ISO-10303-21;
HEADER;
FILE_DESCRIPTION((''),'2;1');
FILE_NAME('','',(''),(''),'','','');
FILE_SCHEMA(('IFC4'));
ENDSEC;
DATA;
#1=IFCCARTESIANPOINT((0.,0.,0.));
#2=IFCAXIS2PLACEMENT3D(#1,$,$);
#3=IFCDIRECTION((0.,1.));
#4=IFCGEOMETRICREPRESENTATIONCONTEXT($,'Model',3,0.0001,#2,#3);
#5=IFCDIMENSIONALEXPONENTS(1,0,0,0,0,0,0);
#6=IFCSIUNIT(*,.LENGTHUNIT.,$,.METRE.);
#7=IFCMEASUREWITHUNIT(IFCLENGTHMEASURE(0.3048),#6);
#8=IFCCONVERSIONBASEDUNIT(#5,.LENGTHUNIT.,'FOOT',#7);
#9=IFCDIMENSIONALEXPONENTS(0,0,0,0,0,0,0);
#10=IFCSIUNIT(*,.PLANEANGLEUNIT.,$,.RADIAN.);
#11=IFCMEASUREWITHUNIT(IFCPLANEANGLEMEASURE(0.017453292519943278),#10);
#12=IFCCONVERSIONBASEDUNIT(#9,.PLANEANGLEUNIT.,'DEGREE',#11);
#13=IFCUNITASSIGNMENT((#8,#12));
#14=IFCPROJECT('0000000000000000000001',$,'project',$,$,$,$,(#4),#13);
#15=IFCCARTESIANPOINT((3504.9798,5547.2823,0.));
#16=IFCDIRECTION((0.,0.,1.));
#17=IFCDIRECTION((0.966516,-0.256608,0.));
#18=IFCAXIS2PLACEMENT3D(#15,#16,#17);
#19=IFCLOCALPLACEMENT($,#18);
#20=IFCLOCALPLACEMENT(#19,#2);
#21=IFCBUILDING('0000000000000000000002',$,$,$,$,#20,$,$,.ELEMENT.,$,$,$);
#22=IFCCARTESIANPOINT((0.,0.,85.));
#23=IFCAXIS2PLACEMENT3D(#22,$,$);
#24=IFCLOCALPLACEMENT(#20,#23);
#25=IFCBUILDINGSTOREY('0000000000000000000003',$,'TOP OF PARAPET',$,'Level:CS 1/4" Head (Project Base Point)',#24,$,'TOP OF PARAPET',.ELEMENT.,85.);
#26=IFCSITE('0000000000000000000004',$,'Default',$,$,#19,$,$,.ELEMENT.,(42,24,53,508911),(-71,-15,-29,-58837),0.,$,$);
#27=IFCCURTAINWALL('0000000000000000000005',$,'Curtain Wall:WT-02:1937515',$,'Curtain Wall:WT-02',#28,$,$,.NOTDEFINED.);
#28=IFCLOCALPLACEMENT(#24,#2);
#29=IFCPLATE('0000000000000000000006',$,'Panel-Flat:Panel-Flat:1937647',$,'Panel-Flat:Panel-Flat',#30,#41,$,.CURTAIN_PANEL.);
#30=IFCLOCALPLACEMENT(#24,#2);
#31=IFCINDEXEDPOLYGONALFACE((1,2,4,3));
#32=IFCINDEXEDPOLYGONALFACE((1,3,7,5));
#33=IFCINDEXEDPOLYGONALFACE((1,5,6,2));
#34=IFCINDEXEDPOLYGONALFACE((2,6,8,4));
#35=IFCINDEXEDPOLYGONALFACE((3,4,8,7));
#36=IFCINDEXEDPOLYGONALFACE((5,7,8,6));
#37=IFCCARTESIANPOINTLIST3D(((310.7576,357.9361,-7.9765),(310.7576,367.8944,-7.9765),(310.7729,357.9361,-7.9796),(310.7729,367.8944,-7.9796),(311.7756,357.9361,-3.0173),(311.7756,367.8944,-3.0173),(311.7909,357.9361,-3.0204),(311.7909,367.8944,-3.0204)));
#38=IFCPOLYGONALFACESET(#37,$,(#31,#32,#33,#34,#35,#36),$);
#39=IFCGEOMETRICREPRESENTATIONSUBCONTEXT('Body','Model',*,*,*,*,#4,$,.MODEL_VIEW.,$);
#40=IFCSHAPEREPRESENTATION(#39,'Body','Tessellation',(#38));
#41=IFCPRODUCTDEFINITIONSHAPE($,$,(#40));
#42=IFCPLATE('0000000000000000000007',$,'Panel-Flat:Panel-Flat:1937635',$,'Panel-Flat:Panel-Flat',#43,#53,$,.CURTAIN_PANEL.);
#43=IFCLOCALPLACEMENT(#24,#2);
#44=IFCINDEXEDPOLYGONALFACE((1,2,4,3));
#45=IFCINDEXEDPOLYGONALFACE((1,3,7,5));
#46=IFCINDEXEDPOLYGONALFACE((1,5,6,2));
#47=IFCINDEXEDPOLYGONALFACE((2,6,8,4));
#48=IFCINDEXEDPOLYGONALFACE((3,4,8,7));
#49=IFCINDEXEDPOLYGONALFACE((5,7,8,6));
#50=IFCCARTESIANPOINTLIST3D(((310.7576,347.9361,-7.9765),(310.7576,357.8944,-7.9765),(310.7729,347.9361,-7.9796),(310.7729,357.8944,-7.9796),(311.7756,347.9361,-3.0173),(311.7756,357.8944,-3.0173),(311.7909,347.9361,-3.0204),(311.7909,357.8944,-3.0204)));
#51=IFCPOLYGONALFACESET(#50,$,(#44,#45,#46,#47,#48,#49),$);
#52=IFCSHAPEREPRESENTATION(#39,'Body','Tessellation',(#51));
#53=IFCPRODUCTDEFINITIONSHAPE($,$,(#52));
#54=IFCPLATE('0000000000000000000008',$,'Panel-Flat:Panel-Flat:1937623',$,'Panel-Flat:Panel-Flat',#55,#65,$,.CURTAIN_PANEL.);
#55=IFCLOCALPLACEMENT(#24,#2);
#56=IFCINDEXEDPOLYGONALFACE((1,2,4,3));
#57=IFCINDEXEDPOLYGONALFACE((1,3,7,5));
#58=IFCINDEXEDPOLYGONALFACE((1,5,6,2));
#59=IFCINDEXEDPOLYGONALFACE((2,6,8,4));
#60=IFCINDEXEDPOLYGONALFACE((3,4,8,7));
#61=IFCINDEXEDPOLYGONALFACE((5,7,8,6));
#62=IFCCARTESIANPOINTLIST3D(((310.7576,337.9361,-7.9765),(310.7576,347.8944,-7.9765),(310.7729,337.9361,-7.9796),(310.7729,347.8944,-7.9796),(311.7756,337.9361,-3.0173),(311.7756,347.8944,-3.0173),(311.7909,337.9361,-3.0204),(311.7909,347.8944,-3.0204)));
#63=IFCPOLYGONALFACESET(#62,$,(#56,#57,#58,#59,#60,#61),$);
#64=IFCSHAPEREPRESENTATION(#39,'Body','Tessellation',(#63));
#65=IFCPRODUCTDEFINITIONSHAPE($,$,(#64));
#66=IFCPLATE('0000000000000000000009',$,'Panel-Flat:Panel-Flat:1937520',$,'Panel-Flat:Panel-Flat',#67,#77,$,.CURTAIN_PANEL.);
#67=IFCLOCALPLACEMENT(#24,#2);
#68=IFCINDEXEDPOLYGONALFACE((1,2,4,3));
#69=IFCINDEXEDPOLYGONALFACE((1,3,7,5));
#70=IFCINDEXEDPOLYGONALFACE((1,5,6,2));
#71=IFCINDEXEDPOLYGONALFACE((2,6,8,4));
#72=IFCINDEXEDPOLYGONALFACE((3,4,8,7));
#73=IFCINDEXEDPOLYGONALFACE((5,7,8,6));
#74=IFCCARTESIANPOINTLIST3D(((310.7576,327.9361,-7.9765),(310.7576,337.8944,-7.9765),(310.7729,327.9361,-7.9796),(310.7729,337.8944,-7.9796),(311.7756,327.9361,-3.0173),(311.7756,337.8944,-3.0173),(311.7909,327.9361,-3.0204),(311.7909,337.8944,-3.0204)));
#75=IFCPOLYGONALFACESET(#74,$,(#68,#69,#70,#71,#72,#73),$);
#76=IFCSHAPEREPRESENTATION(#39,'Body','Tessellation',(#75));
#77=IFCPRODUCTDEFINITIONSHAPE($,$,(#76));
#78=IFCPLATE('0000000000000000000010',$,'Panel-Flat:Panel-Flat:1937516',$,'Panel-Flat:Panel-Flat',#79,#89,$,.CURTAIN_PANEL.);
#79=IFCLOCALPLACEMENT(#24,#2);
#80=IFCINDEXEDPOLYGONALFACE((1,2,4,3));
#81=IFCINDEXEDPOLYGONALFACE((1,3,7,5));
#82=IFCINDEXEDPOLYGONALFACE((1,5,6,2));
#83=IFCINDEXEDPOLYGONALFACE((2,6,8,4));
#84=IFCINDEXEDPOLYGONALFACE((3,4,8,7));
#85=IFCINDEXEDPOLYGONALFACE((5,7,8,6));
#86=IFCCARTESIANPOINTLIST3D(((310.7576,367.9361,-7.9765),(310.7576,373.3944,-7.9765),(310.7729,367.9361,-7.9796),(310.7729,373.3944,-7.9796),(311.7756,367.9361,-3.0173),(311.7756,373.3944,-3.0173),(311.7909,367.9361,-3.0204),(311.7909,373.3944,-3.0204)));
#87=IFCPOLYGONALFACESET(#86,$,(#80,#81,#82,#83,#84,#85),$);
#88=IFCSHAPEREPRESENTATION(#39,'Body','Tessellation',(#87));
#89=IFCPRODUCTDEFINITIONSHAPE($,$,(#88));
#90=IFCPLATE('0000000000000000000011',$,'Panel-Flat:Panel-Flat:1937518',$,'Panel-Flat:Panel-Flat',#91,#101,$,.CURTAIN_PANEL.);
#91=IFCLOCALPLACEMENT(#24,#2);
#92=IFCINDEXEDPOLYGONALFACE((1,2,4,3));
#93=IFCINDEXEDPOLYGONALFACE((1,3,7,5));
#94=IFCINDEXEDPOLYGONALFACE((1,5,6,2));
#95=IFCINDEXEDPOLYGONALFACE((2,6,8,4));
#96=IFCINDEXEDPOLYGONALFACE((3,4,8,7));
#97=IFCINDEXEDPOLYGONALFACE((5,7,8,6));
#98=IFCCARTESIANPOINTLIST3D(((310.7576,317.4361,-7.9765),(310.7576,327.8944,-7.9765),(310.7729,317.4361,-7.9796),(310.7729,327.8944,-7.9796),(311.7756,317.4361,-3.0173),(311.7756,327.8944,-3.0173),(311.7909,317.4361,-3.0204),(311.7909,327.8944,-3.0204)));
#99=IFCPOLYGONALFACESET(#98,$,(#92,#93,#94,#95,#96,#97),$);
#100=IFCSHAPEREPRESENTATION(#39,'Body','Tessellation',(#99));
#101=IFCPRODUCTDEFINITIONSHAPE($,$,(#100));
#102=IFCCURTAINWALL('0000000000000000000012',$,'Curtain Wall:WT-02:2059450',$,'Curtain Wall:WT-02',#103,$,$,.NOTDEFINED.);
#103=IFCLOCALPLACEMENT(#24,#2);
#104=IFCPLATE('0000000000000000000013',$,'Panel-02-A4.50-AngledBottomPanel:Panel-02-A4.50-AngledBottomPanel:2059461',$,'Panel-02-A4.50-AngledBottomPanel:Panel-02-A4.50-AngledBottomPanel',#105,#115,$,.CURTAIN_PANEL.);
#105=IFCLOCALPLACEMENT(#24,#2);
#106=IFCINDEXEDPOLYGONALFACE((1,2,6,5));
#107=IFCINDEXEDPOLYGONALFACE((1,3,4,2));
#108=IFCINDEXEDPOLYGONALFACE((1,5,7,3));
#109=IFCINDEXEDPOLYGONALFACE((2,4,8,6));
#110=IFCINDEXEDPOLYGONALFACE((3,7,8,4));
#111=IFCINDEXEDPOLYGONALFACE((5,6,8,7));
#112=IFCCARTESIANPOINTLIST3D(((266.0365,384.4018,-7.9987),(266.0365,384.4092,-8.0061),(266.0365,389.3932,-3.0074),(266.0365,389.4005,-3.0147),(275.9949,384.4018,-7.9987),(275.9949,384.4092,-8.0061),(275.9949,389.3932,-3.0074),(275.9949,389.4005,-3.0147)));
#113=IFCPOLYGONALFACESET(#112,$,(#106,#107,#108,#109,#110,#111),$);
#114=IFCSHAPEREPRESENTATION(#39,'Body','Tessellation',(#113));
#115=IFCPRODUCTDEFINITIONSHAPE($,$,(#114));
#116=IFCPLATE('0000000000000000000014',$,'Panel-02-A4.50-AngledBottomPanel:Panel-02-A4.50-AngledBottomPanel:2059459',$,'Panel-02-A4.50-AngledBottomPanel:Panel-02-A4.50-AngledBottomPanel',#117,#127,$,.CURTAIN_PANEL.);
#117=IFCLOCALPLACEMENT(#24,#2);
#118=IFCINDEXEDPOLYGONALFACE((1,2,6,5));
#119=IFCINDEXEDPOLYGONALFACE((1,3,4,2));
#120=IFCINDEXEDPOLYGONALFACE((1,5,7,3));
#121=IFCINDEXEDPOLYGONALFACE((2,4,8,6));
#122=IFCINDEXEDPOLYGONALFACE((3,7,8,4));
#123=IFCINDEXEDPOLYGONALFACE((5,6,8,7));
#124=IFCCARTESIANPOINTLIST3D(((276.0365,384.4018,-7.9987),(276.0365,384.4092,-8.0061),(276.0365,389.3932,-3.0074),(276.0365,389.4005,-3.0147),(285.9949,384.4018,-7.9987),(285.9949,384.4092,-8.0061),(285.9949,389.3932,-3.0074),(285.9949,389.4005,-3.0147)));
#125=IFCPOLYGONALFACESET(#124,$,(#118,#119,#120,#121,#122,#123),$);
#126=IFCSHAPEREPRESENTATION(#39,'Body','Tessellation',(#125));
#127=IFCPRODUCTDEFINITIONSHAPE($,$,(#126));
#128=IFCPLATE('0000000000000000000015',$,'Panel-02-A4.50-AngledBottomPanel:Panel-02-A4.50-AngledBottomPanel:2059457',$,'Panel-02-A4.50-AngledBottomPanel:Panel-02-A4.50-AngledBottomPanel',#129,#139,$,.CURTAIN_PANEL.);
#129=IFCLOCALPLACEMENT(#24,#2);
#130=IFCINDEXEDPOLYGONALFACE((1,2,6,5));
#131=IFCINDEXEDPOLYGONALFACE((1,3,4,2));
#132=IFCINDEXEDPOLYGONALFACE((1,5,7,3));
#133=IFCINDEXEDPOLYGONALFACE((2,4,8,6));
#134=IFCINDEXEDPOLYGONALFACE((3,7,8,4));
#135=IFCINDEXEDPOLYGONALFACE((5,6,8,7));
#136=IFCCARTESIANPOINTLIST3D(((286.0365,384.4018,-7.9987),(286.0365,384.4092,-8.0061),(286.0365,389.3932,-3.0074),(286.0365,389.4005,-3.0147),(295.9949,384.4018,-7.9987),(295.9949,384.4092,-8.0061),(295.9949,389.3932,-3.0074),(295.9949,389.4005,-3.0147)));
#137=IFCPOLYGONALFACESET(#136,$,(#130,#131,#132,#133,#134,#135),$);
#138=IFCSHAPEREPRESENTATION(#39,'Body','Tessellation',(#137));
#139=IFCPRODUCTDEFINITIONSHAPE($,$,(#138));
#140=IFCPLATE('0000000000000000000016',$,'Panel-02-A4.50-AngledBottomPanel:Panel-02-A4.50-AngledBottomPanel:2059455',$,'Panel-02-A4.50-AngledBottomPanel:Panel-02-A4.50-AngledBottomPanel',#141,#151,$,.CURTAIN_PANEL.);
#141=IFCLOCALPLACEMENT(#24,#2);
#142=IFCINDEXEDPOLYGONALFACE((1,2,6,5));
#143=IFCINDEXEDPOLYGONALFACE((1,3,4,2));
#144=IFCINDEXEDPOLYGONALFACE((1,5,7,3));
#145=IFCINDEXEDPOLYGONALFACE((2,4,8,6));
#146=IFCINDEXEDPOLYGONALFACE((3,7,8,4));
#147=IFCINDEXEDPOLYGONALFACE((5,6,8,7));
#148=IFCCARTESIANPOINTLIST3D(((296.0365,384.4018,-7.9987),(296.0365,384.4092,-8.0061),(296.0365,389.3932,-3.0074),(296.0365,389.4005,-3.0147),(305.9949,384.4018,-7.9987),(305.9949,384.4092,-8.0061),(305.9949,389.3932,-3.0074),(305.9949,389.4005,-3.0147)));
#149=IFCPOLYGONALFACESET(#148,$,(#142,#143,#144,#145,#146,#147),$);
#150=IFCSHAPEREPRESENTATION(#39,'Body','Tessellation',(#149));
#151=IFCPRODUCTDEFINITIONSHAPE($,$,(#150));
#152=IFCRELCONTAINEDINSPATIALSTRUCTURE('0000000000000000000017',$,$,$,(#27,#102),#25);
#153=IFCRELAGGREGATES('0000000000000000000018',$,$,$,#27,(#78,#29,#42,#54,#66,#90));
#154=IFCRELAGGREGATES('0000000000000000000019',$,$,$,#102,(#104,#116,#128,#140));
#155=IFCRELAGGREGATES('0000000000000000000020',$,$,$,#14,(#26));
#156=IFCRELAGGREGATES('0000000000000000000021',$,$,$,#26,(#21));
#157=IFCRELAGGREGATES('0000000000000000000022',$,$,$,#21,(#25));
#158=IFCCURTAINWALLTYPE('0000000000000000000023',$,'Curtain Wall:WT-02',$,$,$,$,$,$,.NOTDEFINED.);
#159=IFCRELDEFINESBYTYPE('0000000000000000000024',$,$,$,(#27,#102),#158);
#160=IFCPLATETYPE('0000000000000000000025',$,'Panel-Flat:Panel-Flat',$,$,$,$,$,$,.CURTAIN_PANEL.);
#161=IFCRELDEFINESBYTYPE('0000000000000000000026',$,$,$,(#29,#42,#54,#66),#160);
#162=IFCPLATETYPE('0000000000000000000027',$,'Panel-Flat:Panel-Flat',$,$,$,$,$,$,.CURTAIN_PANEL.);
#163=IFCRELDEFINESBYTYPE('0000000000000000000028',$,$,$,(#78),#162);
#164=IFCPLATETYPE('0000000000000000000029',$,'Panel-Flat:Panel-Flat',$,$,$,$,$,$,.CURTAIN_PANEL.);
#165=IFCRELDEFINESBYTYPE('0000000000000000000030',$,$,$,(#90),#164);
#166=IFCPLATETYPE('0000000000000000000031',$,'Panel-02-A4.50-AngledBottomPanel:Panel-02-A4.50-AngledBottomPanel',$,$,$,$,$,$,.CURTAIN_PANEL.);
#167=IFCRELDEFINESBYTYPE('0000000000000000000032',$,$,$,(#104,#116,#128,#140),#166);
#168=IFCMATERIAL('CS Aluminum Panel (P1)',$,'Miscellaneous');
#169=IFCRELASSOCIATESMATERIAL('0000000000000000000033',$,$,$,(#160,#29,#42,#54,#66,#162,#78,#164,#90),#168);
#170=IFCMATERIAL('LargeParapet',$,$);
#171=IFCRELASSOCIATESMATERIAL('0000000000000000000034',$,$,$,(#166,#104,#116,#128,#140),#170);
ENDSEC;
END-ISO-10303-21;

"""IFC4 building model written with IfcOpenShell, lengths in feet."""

from ifc_helpers import new_model, entity, si_unit, converted_unit, direction, frame, origin, place, context, subcontext, project, spatial, indexed_curve, outline, extrude, source, transform, mapped, material, type_object, type_shapes, element, aggregate, save


model = new_model("IFC4")

# Units and contexts
model_context = context("Model", 3, precision=0.0001, world=origin(), true_north=direction((0.0, 1.0)))
body_context = subcontext(model_context, "Body", "Model", "MODEL_VIEW")
ifc_project = project(units=[converted_unit("LENGTHUNIT", "FOOT", entity("IfcLengthMeasure", 0.3048), si_unit("LENGTHUNIT", "METRE"), dimensions=[1, 0, 0, 0, 0, 0, 0]), converted_unit("PLANEANGLEUNIT", "DEGREE", entity("IfcPlaneAngleMeasure", 0.017453292519943278), si_unit("PLANEANGLEUNIT", "RADIAN"), dimensions=[0, 0, 0, 0, 0, 0, 0])], contexts=[model_context])

# Site, building, storey
site_placement = place(None, frame((3504.9798, 5547.2823, 0.0), z_axis=(0.0, 0.0, 1.0), x_axis=(0.966516, -0.256608, 0.0)))
site = spatial("IfcSite", under=ifc_project, at=site_placement, Name="Default", CompositionType="ELEMENT", RefLatitude=(42, 24, 53, 508911), RefLongitude=(-71, -15, -29, -58837), RefElevation=0.0)
building_placement = place(site_placement, origin())
building = spatial("IfcBuilding", under=site, at=building_placement, CompositionType="ELEMENT")
storey_placement = place(building_placement, frame((0.0, 0.0, 85.0)))
storey = spatial("IfcBuildingStorey", under=building, at=storey_placement, Name="TOP OF PARAPET", ObjectType="Level:CS 1/4\" Head (Project Base Point)", LongName="TOP OF PARAPET", CompositionType="ELEMENT", Elevation=85.0)

# Curtain wall, plates
curtain_wall_type = type_object("IfcCurtainWallType", Name="Curtain Wall:WT-02", PredefinedType="NOTDEFINED")
ifc_material_1 = material(Name="LargeParapet")
curtain_wall_1_placement = place(storey_placement, frame((0.0, 0.0, -85.0)))
curtain_wall_1 = element("IfcCurtainWall", 1, at=curtain_wall_1_placement, inside=storey, type_object=curtain_wall_type, Name="Curtain Wall:WT-02:1937515", ObjectType="Curtain Wall:WT-02", PredefinedType="NOTDEFINED")
ifc_material_2 = material(Name="CS Aluminum Panel (P1)", Category="Miscellaneous")
plate_type_1 = type_object("IfcPlateType", Name="Panel-Flat:Panel-Flat", PredefinedType="CURTAIN_PANEL", material=ifc_material_2)
shared_shape_1 = source(origin(), body_context, "Body", "SweptSolid", [
    extrude(outline(indexed_curve([(-0.0078, -4.9792), (0.0078, -4.9792), (0.0078, 4.9792), (-0.0078, 4.9792), (-0.0078, -4.9792)], self_intersect=False)), frame((0.0, -0.0078, 0.0208), z_axis=(0.0, 0.0, 1.0), x_axis=(0.0, -1.0, 0.0)), (0.0, 0.0, 1.0), 5.0626),
])
type_shapes(plate_type_1, [shared_shape_1])
plate_1_placement = place(curtain_wall_1_placement, frame((310.7687, 362.9153, 77.0), z_axis=(0.201078, 0.0, 0.979575), x_axis=(0.0, -1.0, 0.0)))
plate_1 = element("IfcPlate", 2, at=plate_1_placement, type_object=plate_type_1, material=ifc_material_2, Name="Panel-Flat:Panel-Flat:1937647", ObjectType="Panel-Flat:Panel-Flat", PredefinedType="CURTAIN_PANEL", context=body_context, shape_type="MappedRepresentation", body=[
    mapped(shared_shape_1, transform((0.0, 0.0, 0.0), scale=1.0)),
])
plate_2_placement = place(curtain_wall_1_placement, frame((310.7687, 352.9153, 77.0), z_axis=(0.201078, 0.0, 0.979575), x_axis=(0.0, -1.0, 0.0)))
plate_2 = element("IfcPlate", 3, at=plate_2_placement, type_object=plate_type_1, material=ifc_material_2, Name="Panel-Flat:Panel-Flat:1937635", ObjectType="Panel-Flat:Panel-Flat", PredefinedType="CURTAIN_PANEL", context=body_context, shape_type="MappedRepresentation", body=[
    mapped(shared_shape_1, transform((0.0, 0.0, 0.0), scale=1.0)),
])
plate_3_placement = place(curtain_wall_1_placement, frame((310.7687, 342.9153, 77.0), z_axis=(0.201078, 0.0, 0.979575), x_axis=(0.0, -1.0, 0.0)))
plate_3 = element("IfcPlate", 4, at=plate_3_placement, type_object=plate_type_1, material=ifc_material_2, Name="Panel-Flat:Panel-Flat:1937623", ObjectType="Panel-Flat:Panel-Flat", PredefinedType="CURTAIN_PANEL", context=body_context, shape_type="MappedRepresentation", body=[
    mapped(shared_shape_1, transform((0.0, 0.0, 0.0), scale=1.0)),
])
plate_4_placement = place(curtain_wall_1_placement, frame((310.7687, 332.9153, 77.0), z_axis=(0.201078, 0.0, 0.979575), x_axis=(0.0, -1.0, 0.0)))
plate_4 = element("IfcPlate", 5, at=plate_4_placement, type_object=plate_type_1, material=ifc_material_2, Name="Panel-Flat:Panel-Flat:1937520", ObjectType="Panel-Flat:Panel-Flat", PredefinedType="CURTAIN_PANEL", context=body_context, shape_type="MappedRepresentation", body=[
    mapped(shared_shape_1, transform((0.0, 0.0, 0.0), scale=1.0)),
])
plate_type_2 = type_object("IfcPlateType", Name="Panel-Flat:Panel-Flat", PredefinedType="CURTAIN_PANEL", material=ifc_material_2)
shared_shape_2 = source(origin(), body_context, "Body", "SweptSolid", [
    extrude(outline(indexed_curve([(-0.0078, -2.7292), (0.0078, -2.7292), (0.0078, 2.7292), (-0.0078, 2.7292), (-0.0078, -2.7292)], self_intersect=False)), frame((0.0, -0.0078, 0.0208), z_axis=(0.0, 0.0, 1.0), x_axis=(0.0, -1.0, 0.0)), (0.0, 0.0, 1.0), 5.0626),
])
type_shapes(plate_type_2, [shared_shape_2])
plate_5_placement = place(curtain_wall_1_placement, frame((310.7687, 370.6653, 77.0), z_axis=(0.201078, 0.0, 0.979575), x_axis=(0.0, -1.0, 0.0)))
plate_5 = element("IfcPlate", 6, at=plate_5_placement, type_object=plate_type_2, material=ifc_material_2, Name="Panel-Flat:Panel-Flat:1937516", ObjectType="Panel-Flat:Panel-Flat", PredefinedType="CURTAIN_PANEL", context=body_context, shape_type="MappedRepresentation", body=[
    mapped(shared_shape_2, transform((0.0, 0.0, 0.0), scale=1.0)),
])
plate_type_3 = type_object("IfcPlateType", Name="Panel-Flat:Panel-Flat", PredefinedType="CURTAIN_PANEL", material=ifc_material_2)
shared_shape_3 = source(origin(), body_context, "Body", "SweptSolid", [
    extrude(outline(indexed_curve([(-0.0078, -5.2292), (0.0078, -5.2292), (0.0078, 5.2292), (-0.0078, 5.2292), (-0.0078, -5.2292)], self_intersect=False)), frame((0.0, -0.0078, 0.0208), z_axis=(0.0, 0.0, 1.0), x_axis=(0.0, -1.0, 0.0)), (0.0, 0.0, 1.0), 5.0626),
])
type_shapes(plate_type_3, [shared_shape_3])
plate_6_placement = place(curtain_wall_1_placement, frame((310.7687, 322.6653, 77.0), z_axis=(0.201078, 0.0, 0.979575), x_axis=(0.0, -1.0, 0.0)))
plate_6 = element("IfcPlate", 7, at=plate_6_placement, type_object=plate_type_3, material=ifc_material_2, Name="Panel-Flat:Panel-Flat:1937518", ObjectType="Panel-Flat:Panel-Flat", PredefinedType="CURTAIN_PANEL", context=body_context, shape_type="MappedRepresentation", body=[
    mapped(shared_shape_3, transform((0.0, 0.0, 0.0), scale=1.0)),
])
aggregate(curtain_wall_1, [plate_5, plate_1, plate_2, plate_3, plate_4, plate_6])

# Curtain wall, plates
curtain_wall_2_placement = place(storey_placement, frame((0.0, 0.0, -85.0)))
curtain_wall_2 = element("IfcCurtainWall", 8, at=curtain_wall_2_placement, inside=storey, type_object=curtain_wall_type, Name="Curtain Wall:WT-02:2059450", ObjectType="Curtain Wall:WT-02", PredefinedType="NOTDEFINED")
plate_type_4 = type_object("IfcPlateType", Name="Panel-02-A4.50-AngledBottomPanel:Panel-02-A4.50-AngledBottomPanel", PredefinedType="CURTAIN_PANEL", material=ifc_material_1)
shared_shape_4 = source(origin(), body_context, "Body", "SweptSolid", [
    extrude(outline(indexed_curve([(-0.0052, -4.9792), (0.0052, -4.9792), (0.0052, 4.9792), (-0.0052, 4.9792), (-0.0052, -4.9792)], self_intersect=False)), frame((0.0, -0.0052, 0.0208), z_axis=(0.0, 0.0, 1.0), x_axis=(0.0, -1.0, 0.0)), (0.0, 0.0, 1.0), 7.0589),
])
type_shapes(plate_type_4, [shared_shape_4])
plate_7_placement = place(curtain_wall_2_placement, frame((271.0157, 384.3944, 76.9792), z_axis=(0.0, 0.707107, 0.707107), x_axis=(1.0, 0.0, 0.0)))
plate_7 = element("IfcPlate", 9, at=plate_7_placement, type_object=plate_type_4, material=ifc_material_1, Name="Panel-02-A4.50-AngledBottomPanel:Panel-02-A4.50-AngledBottomPanel:2059461", ObjectType="Panel-02-A4.50-AngledBottomPanel:Panel-02-A4.50-AngledBottomPanel", PredefinedType="CURTAIN_PANEL", context=body_context, shape_type="MappedRepresentation", body=[
    mapped(shared_shape_4, transform((0.0, 0.0, 0.0), scale=1.0)),
])
plate_8_placement = place(curtain_wall_2_placement, frame((281.0157, 384.3944, 76.9792), z_axis=(0.0, 0.707107, 0.707107), x_axis=(1.0, 0.0, 0.0)))
plate_8 = element("IfcPlate", 10, at=plate_8_placement, type_object=plate_type_4, material=ifc_material_1, Name="Panel-02-A4.50-AngledBottomPanel:Panel-02-A4.50-AngledBottomPanel:2059459", ObjectType="Panel-02-A4.50-AngledBottomPanel:Panel-02-A4.50-AngledBottomPanel", PredefinedType="CURTAIN_PANEL", context=body_context, shape_type="MappedRepresentation", body=[
    mapped(shared_shape_4, transform((0.0, 0.0, 0.0), scale=1.0)),
])
plate_9_placement = place(curtain_wall_2_placement, frame((291.0157, 384.3944, 76.9792), z_axis=(0.0, 0.707107, 0.707107), x_axis=(1.0, 0.0, 0.0)))
plate_9 = element("IfcPlate", 11, at=plate_9_placement, type_object=plate_type_4, material=ifc_material_1, Name="Panel-02-A4.50-AngledBottomPanel:Panel-02-A4.50-AngledBottomPanel:2059457", ObjectType="Panel-02-A4.50-AngledBottomPanel:Panel-02-A4.50-AngledBottomPanel", PredefinedType="CURTAIN_PANEL", context=body_context, shape_type="MappedRepresentation", body=[
    mapped(shared_shape_4, transform((0.0, 0.0, 0.0), scale=1.0)),
])
plate_10_placement = place(curtain_wall_2_placement, frame((301.0157, 384.3944, 76.9792), z_axis=(0.0, 0.707107, 0.707107), x_axis=(1.0, 0.0, 0.0)))
plate_10 = element("IfcPlate", 12, at=plate_10_placement, type_object=plate_type_4, material=ifc_material_1, Name="Panel-02-A4.50-AngledBottomPanel:Panel-02-A4.50-AngledBottomPanel:2059455", ObjectType="Panel-02-A4.50-AngledBottomPanel:Panel-02-A4.50-AngledBottomPanel", PredefinedType="CURTAIN_PANEL", context=body_context, shape_type="MappedRepresentation", body=[
    mapped(shared_shape_4, transform((0.0, 0.0, 0.0), scale=1.0)),
])
aggregate(curtain_wall_2, [plate_7, plate_8, plate_9, plate_10])

save(model, "model.ifc")
